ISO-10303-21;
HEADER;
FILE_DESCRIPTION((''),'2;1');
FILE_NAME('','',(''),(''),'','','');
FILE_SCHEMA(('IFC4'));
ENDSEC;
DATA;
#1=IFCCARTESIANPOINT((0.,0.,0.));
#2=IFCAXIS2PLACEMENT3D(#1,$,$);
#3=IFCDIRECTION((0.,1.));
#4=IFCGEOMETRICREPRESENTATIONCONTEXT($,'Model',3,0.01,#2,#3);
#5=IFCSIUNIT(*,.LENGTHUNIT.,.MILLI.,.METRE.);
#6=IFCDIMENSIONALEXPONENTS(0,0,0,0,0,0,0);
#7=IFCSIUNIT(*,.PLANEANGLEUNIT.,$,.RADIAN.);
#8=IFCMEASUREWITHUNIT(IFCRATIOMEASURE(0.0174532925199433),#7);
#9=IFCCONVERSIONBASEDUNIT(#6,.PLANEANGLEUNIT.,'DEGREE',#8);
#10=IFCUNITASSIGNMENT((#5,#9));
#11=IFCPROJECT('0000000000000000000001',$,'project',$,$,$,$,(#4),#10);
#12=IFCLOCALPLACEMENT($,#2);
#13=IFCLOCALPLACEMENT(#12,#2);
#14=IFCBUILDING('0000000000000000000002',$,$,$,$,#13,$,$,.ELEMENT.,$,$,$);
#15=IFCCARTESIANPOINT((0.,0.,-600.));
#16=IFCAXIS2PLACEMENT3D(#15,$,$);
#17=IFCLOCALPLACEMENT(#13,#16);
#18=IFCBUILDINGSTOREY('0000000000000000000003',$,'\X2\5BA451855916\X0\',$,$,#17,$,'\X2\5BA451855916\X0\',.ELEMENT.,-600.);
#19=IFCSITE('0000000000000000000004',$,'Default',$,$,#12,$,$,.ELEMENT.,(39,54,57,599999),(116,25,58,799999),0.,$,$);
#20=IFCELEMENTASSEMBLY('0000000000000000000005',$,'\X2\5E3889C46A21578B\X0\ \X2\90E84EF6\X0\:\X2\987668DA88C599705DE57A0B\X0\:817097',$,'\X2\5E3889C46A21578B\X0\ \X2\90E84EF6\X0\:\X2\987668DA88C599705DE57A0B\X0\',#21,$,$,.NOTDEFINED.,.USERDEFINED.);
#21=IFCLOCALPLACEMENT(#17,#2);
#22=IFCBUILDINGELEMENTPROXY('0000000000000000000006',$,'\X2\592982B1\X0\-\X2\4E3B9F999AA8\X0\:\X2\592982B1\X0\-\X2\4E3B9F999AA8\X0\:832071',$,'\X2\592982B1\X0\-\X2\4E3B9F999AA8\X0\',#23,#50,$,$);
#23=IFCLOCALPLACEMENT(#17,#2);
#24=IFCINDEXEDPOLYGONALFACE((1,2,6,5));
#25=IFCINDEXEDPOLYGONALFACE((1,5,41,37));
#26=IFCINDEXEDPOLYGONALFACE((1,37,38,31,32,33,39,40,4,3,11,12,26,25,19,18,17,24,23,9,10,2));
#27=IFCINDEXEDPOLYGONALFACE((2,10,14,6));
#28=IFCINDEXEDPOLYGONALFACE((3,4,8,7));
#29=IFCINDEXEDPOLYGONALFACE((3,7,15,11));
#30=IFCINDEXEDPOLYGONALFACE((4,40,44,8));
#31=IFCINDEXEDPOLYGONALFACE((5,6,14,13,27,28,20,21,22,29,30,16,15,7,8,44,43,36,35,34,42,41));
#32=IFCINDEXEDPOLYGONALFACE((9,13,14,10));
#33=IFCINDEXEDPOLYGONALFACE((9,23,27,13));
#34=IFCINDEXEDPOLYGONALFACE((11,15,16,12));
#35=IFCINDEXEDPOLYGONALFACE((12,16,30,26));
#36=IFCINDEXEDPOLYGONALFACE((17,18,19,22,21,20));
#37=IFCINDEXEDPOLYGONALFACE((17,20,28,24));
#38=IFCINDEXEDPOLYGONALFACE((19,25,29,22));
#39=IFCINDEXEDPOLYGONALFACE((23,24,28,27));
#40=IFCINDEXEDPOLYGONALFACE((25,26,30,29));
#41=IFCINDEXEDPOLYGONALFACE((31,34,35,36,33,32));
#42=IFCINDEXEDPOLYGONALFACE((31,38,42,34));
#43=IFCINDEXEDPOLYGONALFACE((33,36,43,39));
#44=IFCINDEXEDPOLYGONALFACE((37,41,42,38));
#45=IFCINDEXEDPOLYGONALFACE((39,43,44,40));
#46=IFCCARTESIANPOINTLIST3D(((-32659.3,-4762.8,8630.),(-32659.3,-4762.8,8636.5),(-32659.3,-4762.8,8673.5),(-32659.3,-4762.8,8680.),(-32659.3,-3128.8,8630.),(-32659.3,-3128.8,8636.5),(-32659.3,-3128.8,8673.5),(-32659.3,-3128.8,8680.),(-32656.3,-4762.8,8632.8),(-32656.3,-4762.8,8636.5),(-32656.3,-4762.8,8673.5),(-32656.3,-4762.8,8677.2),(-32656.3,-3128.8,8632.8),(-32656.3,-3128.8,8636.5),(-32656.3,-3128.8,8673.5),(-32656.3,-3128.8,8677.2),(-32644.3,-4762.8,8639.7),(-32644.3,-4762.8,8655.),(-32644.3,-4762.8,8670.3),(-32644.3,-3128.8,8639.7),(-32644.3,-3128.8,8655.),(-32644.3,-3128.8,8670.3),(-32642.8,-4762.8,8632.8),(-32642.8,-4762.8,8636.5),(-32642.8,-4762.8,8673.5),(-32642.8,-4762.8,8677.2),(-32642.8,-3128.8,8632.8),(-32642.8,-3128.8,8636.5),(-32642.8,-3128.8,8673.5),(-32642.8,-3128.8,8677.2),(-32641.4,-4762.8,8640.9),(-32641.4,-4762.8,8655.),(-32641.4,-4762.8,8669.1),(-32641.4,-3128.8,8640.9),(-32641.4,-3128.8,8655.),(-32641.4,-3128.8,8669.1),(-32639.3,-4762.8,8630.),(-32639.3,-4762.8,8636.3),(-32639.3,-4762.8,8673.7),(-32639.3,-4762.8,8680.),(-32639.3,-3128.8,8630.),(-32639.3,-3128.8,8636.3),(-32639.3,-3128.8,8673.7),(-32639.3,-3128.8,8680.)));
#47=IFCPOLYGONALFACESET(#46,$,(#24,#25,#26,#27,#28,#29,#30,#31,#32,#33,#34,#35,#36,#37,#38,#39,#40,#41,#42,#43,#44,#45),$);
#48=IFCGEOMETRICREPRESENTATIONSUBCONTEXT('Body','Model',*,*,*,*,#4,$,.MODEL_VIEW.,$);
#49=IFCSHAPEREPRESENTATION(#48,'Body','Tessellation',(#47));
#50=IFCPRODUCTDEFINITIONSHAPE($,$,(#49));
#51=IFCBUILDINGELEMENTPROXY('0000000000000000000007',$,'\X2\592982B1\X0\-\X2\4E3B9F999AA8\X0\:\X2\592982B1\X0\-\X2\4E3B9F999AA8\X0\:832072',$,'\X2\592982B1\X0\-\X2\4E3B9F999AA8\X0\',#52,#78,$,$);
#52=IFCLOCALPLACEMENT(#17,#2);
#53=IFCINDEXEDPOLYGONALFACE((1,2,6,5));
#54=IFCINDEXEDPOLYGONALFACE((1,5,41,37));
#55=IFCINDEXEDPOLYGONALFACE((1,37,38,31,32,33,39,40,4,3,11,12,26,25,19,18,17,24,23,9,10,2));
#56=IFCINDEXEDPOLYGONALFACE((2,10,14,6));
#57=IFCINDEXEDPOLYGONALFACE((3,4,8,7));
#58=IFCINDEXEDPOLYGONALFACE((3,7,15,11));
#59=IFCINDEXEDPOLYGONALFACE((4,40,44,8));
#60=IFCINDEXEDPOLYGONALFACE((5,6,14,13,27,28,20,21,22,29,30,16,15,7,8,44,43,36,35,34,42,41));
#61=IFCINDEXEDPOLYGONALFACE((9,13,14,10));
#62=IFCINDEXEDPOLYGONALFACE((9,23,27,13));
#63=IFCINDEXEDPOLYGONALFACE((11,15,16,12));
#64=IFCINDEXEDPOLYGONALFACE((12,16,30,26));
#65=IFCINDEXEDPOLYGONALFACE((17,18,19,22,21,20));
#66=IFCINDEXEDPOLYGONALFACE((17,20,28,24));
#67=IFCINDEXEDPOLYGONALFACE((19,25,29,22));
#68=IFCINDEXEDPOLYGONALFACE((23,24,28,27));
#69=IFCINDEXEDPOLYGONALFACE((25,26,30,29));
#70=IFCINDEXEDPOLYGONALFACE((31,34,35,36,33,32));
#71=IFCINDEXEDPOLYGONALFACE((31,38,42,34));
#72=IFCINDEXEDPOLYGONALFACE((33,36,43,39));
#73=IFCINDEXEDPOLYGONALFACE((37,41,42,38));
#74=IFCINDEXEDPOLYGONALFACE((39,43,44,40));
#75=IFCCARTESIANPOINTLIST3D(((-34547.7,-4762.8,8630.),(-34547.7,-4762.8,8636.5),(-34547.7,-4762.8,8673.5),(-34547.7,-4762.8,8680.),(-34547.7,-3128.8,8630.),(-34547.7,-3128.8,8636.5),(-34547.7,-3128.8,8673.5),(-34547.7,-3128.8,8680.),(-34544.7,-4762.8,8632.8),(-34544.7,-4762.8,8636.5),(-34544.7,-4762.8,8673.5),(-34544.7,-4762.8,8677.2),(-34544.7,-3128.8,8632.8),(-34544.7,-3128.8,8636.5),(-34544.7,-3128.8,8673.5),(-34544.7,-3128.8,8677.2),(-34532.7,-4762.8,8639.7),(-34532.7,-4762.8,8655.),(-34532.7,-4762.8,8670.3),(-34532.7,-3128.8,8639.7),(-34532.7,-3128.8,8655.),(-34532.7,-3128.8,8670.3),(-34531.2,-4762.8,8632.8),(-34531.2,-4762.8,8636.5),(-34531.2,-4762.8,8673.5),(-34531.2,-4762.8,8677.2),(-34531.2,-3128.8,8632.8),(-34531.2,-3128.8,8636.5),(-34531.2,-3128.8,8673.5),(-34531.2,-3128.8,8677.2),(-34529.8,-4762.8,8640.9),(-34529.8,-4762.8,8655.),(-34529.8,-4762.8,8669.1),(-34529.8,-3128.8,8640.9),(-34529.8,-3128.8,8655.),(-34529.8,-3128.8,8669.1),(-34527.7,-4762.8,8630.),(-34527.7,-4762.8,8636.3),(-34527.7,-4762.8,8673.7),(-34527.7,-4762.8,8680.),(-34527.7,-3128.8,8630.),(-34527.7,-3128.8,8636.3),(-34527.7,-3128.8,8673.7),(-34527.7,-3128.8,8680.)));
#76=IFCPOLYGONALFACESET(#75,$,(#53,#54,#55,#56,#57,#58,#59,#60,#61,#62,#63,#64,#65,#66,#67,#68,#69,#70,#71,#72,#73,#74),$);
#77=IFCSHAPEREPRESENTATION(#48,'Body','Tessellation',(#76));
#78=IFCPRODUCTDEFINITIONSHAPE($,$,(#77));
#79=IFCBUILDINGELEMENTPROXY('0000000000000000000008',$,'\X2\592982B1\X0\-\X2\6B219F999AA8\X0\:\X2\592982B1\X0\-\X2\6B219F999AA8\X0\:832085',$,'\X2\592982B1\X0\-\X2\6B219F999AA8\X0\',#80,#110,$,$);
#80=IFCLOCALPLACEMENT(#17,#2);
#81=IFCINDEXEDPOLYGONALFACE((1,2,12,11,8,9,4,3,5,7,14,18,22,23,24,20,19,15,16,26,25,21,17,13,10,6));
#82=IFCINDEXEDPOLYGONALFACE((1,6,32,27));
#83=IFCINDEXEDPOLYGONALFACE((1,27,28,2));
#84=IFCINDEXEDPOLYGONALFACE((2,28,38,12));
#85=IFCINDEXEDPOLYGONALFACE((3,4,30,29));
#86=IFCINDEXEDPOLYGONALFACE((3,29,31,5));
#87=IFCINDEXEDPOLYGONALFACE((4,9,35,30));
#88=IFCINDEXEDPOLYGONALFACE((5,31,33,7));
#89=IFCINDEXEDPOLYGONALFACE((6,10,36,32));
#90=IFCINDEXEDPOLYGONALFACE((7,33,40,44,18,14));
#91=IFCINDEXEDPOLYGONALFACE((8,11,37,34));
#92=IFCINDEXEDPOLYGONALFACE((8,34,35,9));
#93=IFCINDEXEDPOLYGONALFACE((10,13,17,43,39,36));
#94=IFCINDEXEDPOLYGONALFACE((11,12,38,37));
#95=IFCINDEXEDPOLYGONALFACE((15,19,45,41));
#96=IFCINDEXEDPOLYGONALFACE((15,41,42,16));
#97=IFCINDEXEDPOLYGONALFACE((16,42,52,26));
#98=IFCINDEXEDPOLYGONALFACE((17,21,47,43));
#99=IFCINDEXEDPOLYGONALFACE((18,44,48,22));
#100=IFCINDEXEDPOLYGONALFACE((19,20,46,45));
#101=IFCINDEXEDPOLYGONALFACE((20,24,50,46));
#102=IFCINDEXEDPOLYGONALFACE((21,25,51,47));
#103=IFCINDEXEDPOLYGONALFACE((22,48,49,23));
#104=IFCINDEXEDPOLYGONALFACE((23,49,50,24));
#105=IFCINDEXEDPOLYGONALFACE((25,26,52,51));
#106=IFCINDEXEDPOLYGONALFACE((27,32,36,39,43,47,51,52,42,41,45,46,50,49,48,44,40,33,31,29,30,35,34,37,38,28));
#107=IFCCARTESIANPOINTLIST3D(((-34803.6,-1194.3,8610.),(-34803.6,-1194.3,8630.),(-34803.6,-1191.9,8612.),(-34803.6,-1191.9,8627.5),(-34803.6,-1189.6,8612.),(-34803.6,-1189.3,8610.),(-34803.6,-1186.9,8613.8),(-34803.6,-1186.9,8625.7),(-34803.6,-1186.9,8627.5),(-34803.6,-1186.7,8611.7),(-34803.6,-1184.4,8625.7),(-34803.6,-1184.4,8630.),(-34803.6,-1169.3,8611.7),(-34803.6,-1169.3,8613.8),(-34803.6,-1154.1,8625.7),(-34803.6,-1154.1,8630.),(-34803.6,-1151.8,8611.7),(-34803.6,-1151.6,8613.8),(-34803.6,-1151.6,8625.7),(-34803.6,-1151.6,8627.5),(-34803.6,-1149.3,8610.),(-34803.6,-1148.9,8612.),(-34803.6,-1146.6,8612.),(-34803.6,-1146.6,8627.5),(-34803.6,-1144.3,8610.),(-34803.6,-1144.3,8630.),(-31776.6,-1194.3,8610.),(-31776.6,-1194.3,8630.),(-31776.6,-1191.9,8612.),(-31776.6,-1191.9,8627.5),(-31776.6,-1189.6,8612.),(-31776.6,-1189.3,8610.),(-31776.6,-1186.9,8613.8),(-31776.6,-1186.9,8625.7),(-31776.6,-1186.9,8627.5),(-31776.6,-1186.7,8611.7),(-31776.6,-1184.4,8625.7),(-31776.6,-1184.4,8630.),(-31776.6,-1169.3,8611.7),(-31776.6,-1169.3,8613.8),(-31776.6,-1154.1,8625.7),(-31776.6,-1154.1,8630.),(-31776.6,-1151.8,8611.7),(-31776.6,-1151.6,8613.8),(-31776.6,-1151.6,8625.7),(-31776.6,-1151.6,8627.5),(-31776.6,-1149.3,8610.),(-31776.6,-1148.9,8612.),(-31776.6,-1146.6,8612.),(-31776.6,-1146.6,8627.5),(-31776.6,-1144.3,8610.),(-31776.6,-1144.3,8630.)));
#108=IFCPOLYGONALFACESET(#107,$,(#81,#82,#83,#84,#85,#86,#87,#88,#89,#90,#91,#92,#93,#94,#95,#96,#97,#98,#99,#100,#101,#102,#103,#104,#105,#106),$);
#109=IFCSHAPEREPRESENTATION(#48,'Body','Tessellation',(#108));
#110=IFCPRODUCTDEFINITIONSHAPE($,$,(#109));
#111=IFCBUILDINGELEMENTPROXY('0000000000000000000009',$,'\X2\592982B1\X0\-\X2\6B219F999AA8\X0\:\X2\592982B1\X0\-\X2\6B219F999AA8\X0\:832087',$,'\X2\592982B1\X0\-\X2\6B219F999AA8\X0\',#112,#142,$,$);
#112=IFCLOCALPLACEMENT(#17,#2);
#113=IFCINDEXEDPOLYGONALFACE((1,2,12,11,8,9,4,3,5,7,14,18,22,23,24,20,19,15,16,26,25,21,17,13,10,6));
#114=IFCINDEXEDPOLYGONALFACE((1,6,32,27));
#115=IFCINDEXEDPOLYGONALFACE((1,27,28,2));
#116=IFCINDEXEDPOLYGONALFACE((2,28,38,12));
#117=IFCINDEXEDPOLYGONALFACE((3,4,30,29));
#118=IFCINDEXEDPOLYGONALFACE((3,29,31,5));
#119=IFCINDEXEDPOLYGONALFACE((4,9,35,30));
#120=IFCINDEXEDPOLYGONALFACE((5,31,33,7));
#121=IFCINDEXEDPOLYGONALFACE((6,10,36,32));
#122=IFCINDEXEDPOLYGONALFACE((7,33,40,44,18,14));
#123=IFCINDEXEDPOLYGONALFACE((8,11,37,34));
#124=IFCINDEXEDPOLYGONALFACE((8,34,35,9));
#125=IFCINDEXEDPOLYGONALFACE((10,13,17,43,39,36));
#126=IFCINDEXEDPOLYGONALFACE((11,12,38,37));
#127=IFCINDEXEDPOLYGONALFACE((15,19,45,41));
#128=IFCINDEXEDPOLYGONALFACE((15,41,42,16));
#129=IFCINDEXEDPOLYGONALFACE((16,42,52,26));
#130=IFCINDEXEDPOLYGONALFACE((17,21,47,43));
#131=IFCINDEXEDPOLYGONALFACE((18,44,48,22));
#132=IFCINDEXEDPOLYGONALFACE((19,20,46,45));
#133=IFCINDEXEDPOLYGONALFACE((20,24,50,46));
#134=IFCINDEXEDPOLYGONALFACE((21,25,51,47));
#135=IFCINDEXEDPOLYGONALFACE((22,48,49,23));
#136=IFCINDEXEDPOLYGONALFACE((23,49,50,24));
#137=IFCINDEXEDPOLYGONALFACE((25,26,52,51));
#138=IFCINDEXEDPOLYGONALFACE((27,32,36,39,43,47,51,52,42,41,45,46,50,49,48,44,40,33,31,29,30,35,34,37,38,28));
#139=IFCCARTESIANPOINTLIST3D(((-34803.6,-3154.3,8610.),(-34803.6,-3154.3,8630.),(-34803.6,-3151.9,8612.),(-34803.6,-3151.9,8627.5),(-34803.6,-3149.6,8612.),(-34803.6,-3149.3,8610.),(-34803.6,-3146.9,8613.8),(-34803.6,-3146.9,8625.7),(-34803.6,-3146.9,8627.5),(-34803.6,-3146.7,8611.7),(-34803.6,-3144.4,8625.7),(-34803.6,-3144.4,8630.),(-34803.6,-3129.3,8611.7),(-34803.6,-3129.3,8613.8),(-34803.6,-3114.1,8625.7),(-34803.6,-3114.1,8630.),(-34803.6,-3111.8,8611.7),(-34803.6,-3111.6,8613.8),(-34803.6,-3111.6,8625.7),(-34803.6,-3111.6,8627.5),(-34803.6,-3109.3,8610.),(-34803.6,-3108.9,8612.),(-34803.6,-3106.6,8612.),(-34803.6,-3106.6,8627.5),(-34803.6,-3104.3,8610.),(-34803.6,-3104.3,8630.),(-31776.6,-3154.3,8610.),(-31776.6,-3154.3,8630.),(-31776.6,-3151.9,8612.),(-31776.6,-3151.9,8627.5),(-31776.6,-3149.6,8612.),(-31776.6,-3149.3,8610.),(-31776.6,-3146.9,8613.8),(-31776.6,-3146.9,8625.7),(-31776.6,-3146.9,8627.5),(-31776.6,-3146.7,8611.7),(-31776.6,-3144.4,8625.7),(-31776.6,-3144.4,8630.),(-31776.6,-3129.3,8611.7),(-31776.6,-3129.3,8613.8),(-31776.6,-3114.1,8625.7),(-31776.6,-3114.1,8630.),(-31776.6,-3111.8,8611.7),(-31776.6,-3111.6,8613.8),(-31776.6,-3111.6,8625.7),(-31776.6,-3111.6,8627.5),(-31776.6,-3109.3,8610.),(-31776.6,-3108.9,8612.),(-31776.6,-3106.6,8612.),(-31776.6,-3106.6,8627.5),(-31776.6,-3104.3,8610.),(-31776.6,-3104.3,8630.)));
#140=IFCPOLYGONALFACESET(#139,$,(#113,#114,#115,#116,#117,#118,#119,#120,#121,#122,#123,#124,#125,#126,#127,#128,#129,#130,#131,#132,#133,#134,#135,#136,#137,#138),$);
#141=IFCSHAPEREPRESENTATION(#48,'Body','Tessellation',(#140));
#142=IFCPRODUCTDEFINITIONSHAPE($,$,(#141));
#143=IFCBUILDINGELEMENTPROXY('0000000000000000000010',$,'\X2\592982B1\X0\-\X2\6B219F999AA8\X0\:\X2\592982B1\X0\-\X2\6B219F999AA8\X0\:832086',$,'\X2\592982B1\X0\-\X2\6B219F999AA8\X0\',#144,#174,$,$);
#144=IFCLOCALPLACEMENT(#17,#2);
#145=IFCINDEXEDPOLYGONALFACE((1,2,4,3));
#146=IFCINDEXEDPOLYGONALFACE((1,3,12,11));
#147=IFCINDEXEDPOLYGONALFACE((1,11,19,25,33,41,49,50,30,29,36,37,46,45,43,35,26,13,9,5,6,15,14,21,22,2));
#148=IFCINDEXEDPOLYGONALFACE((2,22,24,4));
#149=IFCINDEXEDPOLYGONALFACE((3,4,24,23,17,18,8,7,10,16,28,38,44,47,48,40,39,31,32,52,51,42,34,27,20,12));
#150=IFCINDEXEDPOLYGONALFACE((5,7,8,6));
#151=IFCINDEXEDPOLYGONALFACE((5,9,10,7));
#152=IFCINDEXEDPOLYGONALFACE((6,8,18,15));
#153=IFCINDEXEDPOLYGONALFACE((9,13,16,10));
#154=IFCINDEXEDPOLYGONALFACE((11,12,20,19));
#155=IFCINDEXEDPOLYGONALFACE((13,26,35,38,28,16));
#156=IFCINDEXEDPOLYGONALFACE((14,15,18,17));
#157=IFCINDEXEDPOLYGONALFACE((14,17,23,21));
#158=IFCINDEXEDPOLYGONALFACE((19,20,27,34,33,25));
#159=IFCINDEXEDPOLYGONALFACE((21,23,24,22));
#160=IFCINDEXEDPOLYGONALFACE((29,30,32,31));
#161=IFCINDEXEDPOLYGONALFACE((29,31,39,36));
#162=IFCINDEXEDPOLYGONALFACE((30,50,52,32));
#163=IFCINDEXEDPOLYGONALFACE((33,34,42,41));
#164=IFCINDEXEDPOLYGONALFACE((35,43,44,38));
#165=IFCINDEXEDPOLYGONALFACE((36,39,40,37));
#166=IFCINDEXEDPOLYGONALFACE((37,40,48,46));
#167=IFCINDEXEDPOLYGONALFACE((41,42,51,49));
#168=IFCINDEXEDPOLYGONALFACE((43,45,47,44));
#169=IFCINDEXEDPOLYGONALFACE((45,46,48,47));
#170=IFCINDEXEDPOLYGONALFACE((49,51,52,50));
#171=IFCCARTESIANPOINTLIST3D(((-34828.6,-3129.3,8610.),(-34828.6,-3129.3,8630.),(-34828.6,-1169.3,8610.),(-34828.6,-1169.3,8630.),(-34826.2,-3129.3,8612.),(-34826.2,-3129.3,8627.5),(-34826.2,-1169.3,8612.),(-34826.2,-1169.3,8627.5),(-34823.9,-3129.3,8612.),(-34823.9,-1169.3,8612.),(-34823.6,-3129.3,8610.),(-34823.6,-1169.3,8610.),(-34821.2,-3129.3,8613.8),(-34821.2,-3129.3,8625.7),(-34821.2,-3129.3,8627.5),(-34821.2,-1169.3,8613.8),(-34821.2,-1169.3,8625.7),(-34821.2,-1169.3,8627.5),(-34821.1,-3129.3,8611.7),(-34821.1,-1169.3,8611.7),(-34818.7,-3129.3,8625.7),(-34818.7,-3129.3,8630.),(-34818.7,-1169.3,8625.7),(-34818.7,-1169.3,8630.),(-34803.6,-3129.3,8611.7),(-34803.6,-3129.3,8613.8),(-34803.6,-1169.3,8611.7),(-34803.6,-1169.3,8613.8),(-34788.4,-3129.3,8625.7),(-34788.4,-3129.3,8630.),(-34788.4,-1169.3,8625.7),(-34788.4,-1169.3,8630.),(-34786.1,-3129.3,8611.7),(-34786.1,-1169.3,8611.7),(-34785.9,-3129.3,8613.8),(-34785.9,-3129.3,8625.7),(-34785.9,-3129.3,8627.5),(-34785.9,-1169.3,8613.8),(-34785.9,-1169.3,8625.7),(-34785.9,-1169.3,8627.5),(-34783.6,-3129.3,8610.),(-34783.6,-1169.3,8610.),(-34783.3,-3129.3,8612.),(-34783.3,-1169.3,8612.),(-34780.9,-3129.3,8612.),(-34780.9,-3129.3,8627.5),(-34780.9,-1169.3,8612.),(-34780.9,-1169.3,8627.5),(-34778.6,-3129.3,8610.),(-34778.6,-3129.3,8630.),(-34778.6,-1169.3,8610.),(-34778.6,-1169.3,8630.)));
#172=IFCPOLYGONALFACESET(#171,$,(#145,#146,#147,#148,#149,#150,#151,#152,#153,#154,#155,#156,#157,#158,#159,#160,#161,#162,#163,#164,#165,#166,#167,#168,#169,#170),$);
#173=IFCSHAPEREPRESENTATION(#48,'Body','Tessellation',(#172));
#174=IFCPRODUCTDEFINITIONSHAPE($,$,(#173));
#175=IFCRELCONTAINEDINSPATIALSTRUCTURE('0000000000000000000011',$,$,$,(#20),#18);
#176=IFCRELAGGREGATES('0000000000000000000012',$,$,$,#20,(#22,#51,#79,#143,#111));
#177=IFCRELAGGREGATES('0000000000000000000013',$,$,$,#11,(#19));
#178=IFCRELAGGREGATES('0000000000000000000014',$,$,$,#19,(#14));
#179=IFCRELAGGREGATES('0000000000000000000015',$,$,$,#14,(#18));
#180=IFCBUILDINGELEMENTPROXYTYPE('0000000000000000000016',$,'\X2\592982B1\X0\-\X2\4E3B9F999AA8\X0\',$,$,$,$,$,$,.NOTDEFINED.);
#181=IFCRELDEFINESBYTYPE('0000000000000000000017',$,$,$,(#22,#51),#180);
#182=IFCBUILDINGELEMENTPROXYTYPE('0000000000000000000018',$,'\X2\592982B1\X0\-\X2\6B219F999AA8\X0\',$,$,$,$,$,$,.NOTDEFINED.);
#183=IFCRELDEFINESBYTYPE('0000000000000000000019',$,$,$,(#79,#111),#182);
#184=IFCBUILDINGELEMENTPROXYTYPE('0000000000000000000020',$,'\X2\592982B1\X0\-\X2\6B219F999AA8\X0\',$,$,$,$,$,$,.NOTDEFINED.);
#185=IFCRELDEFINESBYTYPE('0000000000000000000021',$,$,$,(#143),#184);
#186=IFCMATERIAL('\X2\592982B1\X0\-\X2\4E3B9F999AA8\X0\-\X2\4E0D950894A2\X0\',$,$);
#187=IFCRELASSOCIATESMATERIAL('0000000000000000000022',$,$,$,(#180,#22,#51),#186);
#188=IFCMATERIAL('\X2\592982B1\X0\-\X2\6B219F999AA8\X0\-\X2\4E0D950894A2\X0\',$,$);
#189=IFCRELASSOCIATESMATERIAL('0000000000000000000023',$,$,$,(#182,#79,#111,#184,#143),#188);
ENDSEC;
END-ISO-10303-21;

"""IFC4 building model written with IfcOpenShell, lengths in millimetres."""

from ifc_helpers import new_model, entity, si_unit, converted_unit, direction, frame, origin, place, context, subcontext, project, spatial, polyline, outline, extrude, source, transform, mapped, material, type_object, type_shapes, element, aggregate, save


model = new_model("IFC4")

# Units and contexts
model_context = context("Model", 3, precision=0.01, world=origin(), true_north=direction((0.0, 1.0)))
body_context = subcontext(model_context, "Body", "Model", "MODEL_VIEW")
ifc_project = project(units=[si_unit("LENGTHUNIT", "METRE", prefix="MILLI"), converted_unit("PLANEANGLEUNIT", "DEGREE", entity("IfcRatioMeasure", 0.0174532925199433), si_unit("PLANEANGLEUNIT", "RADIAN"), dimensions=[0, 0, 0, 0, 0, 0, 0])], contexts=[model_context])

# Site, building, storey
site_placement = place(None, origin())
site = spatial("IfcSite", under=ifc_project, at=site_placement, Name="Default", CompositionType="ELEMENT", RefLatitude=(39, 54, 57, 599999), RefLongitude=(116, 25, 58, 799999), RefElevation=0.0)
building_placement = place(site_placement, origin())
building = spatial("IfcBuilding", under=site, at=building_placement, CompositionType="ELEMENT")
storey_placement = place(building_placement, frame((0.0, 0.0, -600.0)))
storey = spatial("IfcBuildingStorey", under=building, at=storey_placement, Name="室内外", LongName="室内外", CompositionType="ELEMENT", Elevation=-600.0)

# Element assembly, building element proxies
assembly_placement = place(storey_placement, origin())
assembly = element("IfcElementAssembly", 1, at=assembly_placement, inside=storey, Name="常规模型 部件:顶棚装饰工程:817097", ObjectType="常规模型 部件:顶棚装饰工程", AssemblyPlace="NOTDEFINED", PredefinedType="USERDEFINED")
ifc_material_1 = material(Name="天花-次龙骨-不锈钢")
ifc_material_2 = material(Name="天花-主龙骨-不锈钢")
building_element_proxy_type_1 = type_object("IfcBuildingElementProxyType", Name="天花-主龙骨", PredefinedType="NOTDEFINED", material=ifc_material_2)
shared_shape_1 = source(origin(), body_context, "Body", "SweptSolid", [
    extrude(outline(polyline([(-25.0, -11.7), (-18.5, -11.7), (-18.5, -8.7), (-22.2, -8.7), (-22.2, 4.8), (-18.5, 4.8), (-15.3, 3.3), (0.0, 3.3), (15.3, 3.3), (18.5, 4.8), (22.2, 4.8), (22.2, -8.7), (18.5, -8.7), (18.5, -11.7), (25.0, -11.7), (25.0, 8.3), (18.7, 8.3), (14.1, 6.2), (0.0, 6.2), (-14.1, 6.2), (-18.7, 8.3), (-25.0, 8.3), (-25.0, -11.7)])), frame((0.0, 1.7, 0.0), z_axis=(1.0, 0.0, 0.0), x_axis=(0.0, 0.0, -1.0)), (0.0, 0.0, 1.0), 1634.0),
])
type_shapes(building_element_proxy_type_1, [shared_shape_1])
proxy_1_placement = place(assembly_placement, frame((-32649.3, -3128.8, 8655.0), z_axis=(0.0, 0.0, 1.0), x_axis=(0.0, -1.0, 0.0)))
proxy_1 = element("IfcBuildingElementProxy", 2, at=proxy_1_placement, type_object=building_element_proxy_type_1, material=ifc_material_2, Name="天花-主龙骨:天花-主龙骨:832071", ObjectType="天花-主龙骨", context=body_context, shape_type="MappedRepresentation", body=[
    mapped(shared_shape_1, transform((0.0, 0.0, 0.0), scale=1.0)),
])
proxy_2_placement = place(assembly_placement, frame((-34537.7, -3128.8, 8655.0), z_axis=(0.0, 0.0, 1.0), x_axis=(0.0, -1.0, 0.0)))
proxy_2 = element("IfcBuildingElementProxy", 3, at=proxy_2_placement, type_object=building_element_proxy_type_1, material=ifc_material_2, Name="天花-主龙骨:天花-主龙骨:832072", ObjectType="天花-主龙骨", context=body_context, shape_type="MappedRepresentation", body=[
    mapped(shared_shape_1, transform((0.0, 0.0, 0.0), scale=1.0)),
])
building_element_proxy_type_2 = type_object("IfcBuildingElementProxyType", Name="天花-次龙骨", PredefinedType="NOTDEFINED", material=ifc_material_1)
shared_shape_2 = source(origin(), body_context, "Body", "SweptSolid", [
    extrude(outline(polyline([(-25.0, -9.1), (-20.0, -9.1), (-17.5, -7.4), (0.0, -7.4), (17.5, -7.4), (20.0, -9.1), (25.0, -9.1), (25.0, 10.9), (15.1, 10.9), (15.1, 6.6), (17.6, 6.6), (17.6, 8.4), (22.6, 8.4), (22.6, -7.1), (20.3, -7.1), (17.6, -5.3), (0.0, -5.3), (-17.6, -5.3), (-20.3, -7.1), (-22.6, -7.1), (-22.6, 8.4), (-17.6, 8.4), (-17.6, 6.6), (-15.1, 6.6), (-15.1, 10.9), (-25.0, 10.9), (-25.0, -9.1)])), frame((0.0, 0.0, -0.9), z_axis=(1.0, 0.0, 0.0), x_axis=(0.0, 1.0, 0.0)), (0.0, 0.0, 1.0), 3027.0),
])
type_shapes(building_element_proxy_type_2, [shared_shape_2])
proxy_3_placement = place(assembly_placement, frame((-34803.6, -1169.3, 8620.0)))
proxy_3 = element("IfcBuildingElementProxy", 4, at=proxy_3_placement, type_object=building_element_proxy_type_2, material=ifc_material_1, Name="天花-次龙骨:天花-次龙骨:832085", ObjectType="天花-次龙骨", context=body_context, shape_type="MappedRepresentation", body=[
    mapped(shared_shape_2, transform((0.0, 0.0, 0.0), scale=1.0)),
])
proxy_4_placement = place(assembly_placement, frame((-34803.6, -3129.3, 8620.0)))
proxy_4 = element("IfcBuildingElementProxy", 5, at=proxy_4_placement, type_object=building_element_proxy_type_2, material=ifc_material_1, Name="天花-次龙骨:天花-次龙骨:832087", ObjectType="天花-次龙骨", context=body_context, shape_type="MappedRepresentation", body=[
    mapped(shared_shape_2, transform((0.0, 0.0, 0.0), scale=1.0)),
])
building_element_proxy_type_3 = type_object("IfcBuildingElementProxyType", Name="天花-次龙骨", PredefinedType="NOTDEFINED", material=ifc_material_1)
shared_shape_3 = source(origin(), body_context, "Body", "SweptSolid", [
    extrude(outline(polyline([(-25.0, -9.1), (-20.0, -9.1), (-17.5, -7.4), (0.0, -7.4), (17.5, -7.4), (20.0, -9.1), (25.0, -9.1), (25.0, 10.9), (15.1, 10.9), (15.1, 6.6), (17.6, 6.6), (17.6, 8.4), (22.6, 8.4), (22.6, -7.1), (20.3, -7.1), (17.6, -5.3), (0.0, -5.3), (-17.6, -5.3), (-20.3, -7.1), (-22.6, -7.1), (-22.6, 8.4), (-17.6, 8.4), (-17.6, 6.6), (-15.1, 6.6), (-15.1, 10.9), (-25.0, 10.9), (-25.0, -9.1)])), frame((0.0, 0.0, -0.9), z_axis=(1.0, 0.0, 0.0), x_axis=(0.0, 1.0, 0.0)), (0.0, 0.0, 1.0), 1960.0),
])
type_shapes(building_element_proxy_type_3, [shared_shape_3])
proxy_5_placement = place(assembly_placement, frame((-34803.6, -1169.3, 8620.0), z_axis=(0.0, 0.0, 1.0), x_axis=(0.0, -1.0, 0.0)))
proxy_5 = element("IfcBuildingElementProxy", 6, at=proxy_5_placement, type_object=building_element_proxy_type_3, material=ifc_material_1, Name="天花-次龙骨:天花-次龙骨:832086", ObjectType="天花-次龙骨", context=body_context, shape_type="MappedRepresentation", body=[
    mapped(shared_shape_3, transform((0.0, 0.0, 0.0), scale=1.0)),
])
aggregate(assembly, [proxy_1, proxy_2, proxy_3, proxy_5, proxy_4])

save(model, "model.ifc")
